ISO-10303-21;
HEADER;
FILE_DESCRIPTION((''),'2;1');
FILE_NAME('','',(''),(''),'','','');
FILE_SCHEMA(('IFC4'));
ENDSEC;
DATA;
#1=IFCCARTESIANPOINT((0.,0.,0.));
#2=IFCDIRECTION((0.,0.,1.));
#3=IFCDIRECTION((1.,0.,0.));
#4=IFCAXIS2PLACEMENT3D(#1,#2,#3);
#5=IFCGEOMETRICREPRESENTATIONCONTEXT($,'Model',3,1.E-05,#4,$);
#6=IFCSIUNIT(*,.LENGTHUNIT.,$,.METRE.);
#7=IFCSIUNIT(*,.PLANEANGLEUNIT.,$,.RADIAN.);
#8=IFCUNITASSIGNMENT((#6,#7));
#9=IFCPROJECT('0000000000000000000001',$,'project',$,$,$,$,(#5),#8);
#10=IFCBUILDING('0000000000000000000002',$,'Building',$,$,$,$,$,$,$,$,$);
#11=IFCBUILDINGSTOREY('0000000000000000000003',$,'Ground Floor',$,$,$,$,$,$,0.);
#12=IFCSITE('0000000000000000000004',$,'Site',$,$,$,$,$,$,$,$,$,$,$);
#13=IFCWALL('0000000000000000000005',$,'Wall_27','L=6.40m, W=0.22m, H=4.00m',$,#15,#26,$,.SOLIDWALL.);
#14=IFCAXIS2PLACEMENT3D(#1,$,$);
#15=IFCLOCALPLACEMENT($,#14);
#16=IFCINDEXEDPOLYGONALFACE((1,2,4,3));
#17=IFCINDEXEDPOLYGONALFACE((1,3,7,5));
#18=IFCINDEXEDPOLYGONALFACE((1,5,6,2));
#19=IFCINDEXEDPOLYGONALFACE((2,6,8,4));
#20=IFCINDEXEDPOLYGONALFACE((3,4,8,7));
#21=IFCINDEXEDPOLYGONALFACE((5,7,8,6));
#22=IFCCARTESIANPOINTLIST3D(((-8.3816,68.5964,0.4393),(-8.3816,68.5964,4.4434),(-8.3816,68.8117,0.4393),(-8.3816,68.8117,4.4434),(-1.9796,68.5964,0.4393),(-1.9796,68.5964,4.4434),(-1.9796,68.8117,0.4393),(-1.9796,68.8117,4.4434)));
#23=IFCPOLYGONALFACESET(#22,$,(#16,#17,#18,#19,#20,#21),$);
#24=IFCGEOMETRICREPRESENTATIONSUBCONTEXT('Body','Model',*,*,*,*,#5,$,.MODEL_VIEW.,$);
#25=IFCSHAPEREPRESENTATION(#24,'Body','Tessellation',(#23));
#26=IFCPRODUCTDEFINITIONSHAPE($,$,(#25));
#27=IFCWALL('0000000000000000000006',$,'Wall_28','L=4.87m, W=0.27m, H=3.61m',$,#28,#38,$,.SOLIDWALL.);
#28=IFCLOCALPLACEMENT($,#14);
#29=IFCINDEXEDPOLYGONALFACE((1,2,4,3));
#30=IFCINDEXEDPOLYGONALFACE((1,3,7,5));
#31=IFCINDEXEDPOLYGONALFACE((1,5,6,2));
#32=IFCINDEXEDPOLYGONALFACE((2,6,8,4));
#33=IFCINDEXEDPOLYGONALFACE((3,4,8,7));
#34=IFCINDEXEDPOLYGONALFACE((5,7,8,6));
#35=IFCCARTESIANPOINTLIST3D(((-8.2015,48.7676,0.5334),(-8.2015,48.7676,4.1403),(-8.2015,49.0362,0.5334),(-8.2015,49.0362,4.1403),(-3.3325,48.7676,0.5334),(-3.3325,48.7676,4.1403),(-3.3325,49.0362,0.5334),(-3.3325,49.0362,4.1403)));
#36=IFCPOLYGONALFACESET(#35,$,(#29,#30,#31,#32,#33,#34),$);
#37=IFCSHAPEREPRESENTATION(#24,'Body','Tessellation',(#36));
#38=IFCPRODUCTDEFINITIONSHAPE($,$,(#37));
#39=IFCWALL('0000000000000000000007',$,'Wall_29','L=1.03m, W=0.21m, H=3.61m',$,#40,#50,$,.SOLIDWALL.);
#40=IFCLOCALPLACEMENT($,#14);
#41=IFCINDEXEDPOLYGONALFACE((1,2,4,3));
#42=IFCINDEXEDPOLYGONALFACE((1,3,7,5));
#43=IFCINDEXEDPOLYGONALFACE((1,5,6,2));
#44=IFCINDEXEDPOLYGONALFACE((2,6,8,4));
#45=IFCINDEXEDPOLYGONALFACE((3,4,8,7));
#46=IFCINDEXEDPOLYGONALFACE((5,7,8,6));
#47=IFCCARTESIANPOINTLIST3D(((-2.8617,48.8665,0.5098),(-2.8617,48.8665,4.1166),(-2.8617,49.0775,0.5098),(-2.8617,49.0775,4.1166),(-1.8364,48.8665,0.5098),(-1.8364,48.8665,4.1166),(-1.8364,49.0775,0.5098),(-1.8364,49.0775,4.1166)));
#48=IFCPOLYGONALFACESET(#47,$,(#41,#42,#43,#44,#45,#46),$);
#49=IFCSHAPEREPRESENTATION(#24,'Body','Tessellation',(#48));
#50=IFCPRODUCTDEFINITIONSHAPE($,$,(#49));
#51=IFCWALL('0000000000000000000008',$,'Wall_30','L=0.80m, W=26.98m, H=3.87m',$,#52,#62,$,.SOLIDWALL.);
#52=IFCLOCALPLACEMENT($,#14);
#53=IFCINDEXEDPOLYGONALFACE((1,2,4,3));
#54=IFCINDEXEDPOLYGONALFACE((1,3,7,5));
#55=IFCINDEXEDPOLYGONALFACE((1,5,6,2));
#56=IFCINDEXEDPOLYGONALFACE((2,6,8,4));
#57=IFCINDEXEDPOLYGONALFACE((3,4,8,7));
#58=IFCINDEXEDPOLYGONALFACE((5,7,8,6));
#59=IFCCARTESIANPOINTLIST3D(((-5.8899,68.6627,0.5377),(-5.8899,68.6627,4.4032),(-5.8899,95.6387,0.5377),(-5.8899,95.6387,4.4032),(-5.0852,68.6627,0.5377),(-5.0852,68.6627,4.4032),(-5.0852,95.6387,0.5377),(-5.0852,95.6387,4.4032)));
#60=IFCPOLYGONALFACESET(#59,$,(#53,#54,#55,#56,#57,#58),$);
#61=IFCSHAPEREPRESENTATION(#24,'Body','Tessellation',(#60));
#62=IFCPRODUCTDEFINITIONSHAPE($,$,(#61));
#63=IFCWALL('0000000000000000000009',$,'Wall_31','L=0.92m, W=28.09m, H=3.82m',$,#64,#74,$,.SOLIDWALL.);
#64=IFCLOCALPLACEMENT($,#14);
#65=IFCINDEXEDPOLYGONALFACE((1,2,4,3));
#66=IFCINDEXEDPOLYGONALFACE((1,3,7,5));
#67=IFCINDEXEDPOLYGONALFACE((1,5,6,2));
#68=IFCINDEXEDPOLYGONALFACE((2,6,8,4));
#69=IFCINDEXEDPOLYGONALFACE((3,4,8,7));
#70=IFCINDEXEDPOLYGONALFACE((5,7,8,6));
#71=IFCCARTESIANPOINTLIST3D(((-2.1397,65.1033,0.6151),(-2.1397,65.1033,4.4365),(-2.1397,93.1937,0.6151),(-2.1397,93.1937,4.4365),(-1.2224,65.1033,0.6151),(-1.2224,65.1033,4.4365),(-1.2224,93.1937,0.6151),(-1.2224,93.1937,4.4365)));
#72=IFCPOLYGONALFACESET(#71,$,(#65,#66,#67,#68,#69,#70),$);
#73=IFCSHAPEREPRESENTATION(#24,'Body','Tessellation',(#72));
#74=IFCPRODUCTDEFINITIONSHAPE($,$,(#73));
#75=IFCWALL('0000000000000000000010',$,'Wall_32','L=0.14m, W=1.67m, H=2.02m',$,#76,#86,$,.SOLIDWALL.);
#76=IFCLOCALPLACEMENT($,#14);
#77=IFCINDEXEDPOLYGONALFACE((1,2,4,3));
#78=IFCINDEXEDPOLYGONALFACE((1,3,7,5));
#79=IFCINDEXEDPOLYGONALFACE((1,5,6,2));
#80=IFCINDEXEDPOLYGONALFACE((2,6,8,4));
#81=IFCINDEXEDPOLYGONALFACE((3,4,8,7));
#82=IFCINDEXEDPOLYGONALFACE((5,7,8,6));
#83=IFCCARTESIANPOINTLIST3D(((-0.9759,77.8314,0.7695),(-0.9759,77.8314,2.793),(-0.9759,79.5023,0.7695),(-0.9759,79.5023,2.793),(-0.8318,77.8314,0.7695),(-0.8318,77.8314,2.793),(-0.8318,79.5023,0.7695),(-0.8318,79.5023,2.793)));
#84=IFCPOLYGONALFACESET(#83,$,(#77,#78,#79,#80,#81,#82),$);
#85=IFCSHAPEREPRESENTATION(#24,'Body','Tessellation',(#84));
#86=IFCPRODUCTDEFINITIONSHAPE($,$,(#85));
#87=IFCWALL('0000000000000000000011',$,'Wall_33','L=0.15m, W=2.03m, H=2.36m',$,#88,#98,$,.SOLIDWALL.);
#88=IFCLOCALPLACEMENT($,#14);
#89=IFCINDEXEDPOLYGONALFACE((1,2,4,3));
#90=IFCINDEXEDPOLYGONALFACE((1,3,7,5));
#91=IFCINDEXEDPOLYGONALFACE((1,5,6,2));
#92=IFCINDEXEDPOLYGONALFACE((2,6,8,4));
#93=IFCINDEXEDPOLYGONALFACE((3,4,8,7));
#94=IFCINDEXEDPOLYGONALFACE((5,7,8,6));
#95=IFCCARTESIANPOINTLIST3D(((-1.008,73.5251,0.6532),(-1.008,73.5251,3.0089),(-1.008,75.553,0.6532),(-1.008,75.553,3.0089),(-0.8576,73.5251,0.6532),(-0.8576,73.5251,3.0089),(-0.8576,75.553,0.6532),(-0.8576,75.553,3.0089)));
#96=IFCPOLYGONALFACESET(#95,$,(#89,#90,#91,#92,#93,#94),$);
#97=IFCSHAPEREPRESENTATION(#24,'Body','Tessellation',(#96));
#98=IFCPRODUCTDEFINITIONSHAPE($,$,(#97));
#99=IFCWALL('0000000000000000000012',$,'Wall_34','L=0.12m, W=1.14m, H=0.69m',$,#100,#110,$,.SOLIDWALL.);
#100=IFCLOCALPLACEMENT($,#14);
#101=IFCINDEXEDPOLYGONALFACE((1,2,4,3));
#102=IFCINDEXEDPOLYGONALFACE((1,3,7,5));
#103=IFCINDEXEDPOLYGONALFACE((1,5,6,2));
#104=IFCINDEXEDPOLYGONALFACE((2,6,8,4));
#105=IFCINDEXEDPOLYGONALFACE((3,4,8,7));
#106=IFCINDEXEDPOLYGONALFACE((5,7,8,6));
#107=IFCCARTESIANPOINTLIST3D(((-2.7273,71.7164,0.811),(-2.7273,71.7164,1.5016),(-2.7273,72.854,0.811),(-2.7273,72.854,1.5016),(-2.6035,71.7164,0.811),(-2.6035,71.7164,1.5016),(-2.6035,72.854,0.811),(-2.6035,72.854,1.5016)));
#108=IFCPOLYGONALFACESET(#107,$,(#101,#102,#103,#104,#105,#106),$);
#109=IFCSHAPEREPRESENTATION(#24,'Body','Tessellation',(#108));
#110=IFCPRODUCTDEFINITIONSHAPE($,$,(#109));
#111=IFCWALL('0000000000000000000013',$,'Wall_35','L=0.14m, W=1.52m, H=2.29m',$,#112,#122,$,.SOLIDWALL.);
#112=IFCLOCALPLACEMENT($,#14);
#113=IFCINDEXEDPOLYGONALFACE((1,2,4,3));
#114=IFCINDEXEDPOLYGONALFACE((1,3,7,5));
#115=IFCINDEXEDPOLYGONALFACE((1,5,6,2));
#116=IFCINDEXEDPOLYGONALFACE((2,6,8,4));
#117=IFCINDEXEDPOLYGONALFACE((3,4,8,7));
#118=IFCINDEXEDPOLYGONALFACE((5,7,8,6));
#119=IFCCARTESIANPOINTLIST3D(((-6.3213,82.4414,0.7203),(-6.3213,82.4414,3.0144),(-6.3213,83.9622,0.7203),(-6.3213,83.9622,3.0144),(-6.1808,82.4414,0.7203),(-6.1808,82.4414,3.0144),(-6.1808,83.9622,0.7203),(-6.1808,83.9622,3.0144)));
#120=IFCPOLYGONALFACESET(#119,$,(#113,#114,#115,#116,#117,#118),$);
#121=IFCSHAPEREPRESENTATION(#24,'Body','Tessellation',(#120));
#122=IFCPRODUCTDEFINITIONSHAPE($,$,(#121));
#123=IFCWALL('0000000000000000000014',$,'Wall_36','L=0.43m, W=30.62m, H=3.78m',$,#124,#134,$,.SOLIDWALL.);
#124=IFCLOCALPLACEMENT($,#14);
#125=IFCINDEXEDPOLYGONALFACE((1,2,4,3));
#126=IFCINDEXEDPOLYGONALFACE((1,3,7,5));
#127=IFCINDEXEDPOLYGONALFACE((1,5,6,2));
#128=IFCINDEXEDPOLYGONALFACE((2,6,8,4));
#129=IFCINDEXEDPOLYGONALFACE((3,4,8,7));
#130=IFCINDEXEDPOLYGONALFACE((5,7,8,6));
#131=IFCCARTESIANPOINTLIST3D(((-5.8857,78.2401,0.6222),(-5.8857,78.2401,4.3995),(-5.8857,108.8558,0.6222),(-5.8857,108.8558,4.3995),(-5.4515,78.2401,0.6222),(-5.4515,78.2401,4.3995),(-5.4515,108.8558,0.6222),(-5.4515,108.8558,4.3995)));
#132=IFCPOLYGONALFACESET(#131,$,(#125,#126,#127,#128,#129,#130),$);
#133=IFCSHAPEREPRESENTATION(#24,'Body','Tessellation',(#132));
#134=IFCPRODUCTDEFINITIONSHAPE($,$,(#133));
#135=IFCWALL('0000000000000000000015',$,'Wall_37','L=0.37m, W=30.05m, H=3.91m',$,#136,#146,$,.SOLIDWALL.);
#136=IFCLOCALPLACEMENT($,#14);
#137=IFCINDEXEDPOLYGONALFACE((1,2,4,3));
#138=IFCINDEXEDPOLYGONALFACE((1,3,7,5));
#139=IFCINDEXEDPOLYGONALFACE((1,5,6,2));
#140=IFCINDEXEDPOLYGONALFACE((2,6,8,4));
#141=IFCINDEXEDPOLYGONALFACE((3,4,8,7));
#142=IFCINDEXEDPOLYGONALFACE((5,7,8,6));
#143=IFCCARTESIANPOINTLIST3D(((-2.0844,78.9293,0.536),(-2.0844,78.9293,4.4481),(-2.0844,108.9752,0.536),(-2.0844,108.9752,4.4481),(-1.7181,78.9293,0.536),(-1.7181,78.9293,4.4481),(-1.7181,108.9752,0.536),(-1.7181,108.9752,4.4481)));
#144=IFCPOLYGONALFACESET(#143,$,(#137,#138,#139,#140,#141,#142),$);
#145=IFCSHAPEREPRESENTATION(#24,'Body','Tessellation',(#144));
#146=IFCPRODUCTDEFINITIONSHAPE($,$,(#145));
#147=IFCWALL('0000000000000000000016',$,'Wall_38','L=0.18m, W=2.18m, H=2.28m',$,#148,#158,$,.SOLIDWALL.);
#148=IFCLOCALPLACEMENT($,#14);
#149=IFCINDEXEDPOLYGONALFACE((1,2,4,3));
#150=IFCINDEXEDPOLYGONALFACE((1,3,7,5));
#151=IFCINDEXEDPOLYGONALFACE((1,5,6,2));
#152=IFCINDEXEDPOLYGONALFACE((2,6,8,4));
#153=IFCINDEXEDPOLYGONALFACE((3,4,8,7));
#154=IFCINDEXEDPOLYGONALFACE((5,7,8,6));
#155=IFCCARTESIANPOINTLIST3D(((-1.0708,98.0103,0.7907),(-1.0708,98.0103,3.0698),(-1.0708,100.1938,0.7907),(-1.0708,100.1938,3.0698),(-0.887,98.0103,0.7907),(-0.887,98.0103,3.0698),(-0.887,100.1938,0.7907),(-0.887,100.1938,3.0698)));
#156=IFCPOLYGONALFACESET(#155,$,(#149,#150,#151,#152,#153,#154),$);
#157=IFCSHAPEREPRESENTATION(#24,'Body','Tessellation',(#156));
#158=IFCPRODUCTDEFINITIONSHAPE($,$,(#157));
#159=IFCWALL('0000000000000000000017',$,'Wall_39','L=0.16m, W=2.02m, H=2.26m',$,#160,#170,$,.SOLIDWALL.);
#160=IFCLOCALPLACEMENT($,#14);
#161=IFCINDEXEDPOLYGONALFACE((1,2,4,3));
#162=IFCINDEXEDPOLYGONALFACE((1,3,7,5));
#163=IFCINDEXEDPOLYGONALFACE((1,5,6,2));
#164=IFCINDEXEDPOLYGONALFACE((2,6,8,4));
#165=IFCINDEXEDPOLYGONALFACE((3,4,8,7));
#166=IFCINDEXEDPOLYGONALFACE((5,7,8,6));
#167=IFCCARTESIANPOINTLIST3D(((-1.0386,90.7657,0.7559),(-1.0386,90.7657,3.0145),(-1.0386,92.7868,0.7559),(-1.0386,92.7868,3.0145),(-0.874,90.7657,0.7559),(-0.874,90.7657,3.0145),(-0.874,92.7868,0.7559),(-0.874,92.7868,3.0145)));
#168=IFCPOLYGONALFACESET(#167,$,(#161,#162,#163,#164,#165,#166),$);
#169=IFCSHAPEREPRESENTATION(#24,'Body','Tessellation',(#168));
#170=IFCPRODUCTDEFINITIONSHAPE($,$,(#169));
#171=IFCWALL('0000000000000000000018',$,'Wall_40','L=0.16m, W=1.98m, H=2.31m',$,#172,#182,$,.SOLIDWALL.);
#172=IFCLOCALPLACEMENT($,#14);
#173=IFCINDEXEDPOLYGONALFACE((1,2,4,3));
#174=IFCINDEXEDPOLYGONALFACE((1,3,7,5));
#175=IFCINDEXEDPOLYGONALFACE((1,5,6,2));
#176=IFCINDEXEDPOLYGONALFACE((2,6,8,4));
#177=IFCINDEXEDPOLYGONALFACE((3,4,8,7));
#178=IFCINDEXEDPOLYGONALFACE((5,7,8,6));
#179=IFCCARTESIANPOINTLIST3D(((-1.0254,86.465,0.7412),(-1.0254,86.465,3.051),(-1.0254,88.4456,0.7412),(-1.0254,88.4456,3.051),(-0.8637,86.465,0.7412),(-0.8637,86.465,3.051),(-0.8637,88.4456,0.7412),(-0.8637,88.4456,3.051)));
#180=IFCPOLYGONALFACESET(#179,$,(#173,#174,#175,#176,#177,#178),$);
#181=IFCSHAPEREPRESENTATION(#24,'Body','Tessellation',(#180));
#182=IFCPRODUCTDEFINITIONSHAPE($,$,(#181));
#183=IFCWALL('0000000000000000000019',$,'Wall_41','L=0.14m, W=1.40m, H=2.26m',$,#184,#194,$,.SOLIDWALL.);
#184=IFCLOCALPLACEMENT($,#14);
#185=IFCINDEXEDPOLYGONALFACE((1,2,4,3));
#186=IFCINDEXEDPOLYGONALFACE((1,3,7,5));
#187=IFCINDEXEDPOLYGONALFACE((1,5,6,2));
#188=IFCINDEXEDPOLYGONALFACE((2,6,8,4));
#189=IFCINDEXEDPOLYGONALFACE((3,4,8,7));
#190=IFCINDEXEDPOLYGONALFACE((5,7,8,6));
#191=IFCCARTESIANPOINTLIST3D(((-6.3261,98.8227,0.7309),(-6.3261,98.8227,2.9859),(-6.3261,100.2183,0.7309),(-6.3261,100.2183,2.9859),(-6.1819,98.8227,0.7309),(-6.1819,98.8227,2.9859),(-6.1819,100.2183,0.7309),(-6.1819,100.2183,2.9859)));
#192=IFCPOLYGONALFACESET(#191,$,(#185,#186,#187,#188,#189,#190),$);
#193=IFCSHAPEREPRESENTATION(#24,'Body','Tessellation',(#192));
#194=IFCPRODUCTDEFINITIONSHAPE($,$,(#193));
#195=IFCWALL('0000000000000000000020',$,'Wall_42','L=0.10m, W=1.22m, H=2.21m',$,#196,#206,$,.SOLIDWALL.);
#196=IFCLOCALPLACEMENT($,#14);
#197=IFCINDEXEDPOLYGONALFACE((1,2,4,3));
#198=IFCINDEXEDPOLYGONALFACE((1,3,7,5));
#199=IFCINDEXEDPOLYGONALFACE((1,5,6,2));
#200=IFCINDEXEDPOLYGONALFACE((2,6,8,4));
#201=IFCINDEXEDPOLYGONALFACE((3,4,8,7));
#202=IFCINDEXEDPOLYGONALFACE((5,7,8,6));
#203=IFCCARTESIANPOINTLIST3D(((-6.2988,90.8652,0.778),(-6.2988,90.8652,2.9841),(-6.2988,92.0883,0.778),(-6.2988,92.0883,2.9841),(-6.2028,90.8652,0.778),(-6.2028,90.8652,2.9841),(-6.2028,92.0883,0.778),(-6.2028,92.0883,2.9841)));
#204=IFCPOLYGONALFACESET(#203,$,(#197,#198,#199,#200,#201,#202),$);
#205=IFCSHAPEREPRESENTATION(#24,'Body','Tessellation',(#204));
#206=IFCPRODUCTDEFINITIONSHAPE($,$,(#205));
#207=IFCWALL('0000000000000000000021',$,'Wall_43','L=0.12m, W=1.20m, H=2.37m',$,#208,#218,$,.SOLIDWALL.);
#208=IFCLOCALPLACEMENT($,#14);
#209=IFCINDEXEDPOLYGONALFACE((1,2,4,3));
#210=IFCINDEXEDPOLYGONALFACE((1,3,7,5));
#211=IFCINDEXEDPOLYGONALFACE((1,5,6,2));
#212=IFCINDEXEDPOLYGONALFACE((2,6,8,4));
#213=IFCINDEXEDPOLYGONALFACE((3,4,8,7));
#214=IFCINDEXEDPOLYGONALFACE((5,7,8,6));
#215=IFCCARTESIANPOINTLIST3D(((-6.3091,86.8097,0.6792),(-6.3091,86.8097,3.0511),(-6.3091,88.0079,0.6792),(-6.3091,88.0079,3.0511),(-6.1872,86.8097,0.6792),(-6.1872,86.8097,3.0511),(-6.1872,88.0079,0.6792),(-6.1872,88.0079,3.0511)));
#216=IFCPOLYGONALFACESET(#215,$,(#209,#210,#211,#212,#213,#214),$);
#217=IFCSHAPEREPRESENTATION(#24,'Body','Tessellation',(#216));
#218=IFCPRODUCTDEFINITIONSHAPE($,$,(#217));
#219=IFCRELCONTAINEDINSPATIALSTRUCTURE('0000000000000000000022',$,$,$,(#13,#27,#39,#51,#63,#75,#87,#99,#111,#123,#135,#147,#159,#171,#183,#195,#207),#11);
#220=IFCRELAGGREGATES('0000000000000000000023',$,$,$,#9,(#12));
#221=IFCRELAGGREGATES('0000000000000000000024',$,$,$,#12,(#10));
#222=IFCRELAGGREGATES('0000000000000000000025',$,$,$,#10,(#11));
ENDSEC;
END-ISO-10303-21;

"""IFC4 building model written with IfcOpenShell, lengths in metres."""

from ifc_helpers import new_model, si_unit, frame, origin_with_axes, origin_2d, context, subcontext, project, spatial, rectangle, extrude, element, save


model = new_model("IFC4")

# Units and contexts
model_context = context("Model", 3, precision=1e-05, world=origin_with_axes())
body_context = subcontext(model_context, "Body", "Model", "MODEL_VIEW")
ifc_project = project(units=[si_unit("LENGTHUNIT", "METRE"), si_unit("PLANEANGLEUNIT", "RADIAN")], contexts=[model_context])

# Site, building, storey
site = spatial("IfcSite", under=ifc_project, Name="Site")
building = spatial("IfcBuilding", under=site, Name="Building")
storey = spatial("IfcBuildingStorey", under=building, Name="Ground Floor", Elevation=0.0)

# Walls
element("IfcWall", 1, inside=storey, Name="Wall_27", Description="L=6.40m, W=0.22m, H=4.00m", PredefinedType="SOLIDWALL", context=body_context, shape_type="SweptSolid", body=[
    extrude(rectangle(XDim=6.4019, YDim=0.2153, at=origin_2d()), frame((-5.1806, 68.704, 0.4393), z_axis=(0.0, 0.0, 1.0), x_axis=(1.0, 0.0, 0.0)), (0.0, 0.0, 1.0), 4.0042),
])
element("IfcWall", 2, inside=storey, Name="Wall_28", Description="L=4.87m, W=0.27m, H=3.61m", PredefinedType="SOLIDWALL", context=body_context, shape_type="SweptSolid", body=[
    extrude(rectangle(XDim=4.869, YDim=0.2687, at=origin_2d()), frame((-5.767, 48.9019, 0.5334), z_axis=(0.0, 0.0, 1.0), x_axis=(1.0, 0.0, 0.0)), (0.0, 0.0, 1.0), 3.6069),
])
element("IfcWall", 3, inside=storey, Name="Wall_29", Description="L=1.03m, W=0.21m, H=3.61m", PredefinedType="SOLIDWALL", context=body_context, shape_type="SweptSolid", body=[
    extrude(rectangle(XDim=1.0253, YDim=0.211, at=origin_2d()), frame((-2.349, 48.972, 0.5098), z_axis=(0.0, 0.0, 1.0), x_axis=(1.0, 0.0, 0.0)), (0.0, 0.0, 1.0), 3.6068),
])
element("IfcWall", 4, inside=storey, Name="Wall_30", Description="L=0.80m, W=26.98m, H=3.87m", PredefinedType="SOLIDWALL", context=body_context, shape_type="SweptSolid", body=[
    extrude(rectangle(XDim=0.8047, YDim=26.976, at=origin_2d()), frame((-5.4875, 82.1507, 0.5377), z_axis=(0.0, 0.0, 1.0), x_axis=(1.0, 0.0, 0.0)), (0.0, 0.0, 1.0), 3.8655),
])
element("IfcWall", 5, inside=storey, Name="Wall_31", Description="L=0.92m, W=28.09m, H=3.82m", PredefinedType="SOLIDWALL", context=body_context, shape_type="SweptSolid", body=[
    extrude(rectangle(XDim=0.9173, YDim=28.0904, at=origin_2d()), frame((-1.681, 79.1485, 0.6151), z_axis=(0.0, 0.0, 1.0), x_axis=(1.0, 0.0, 0.0)), (0.0, 0.0, 1.0), 3.8214),
])
element("IfcWall", 6, inside=storey, Name="Wall_32", Description="L=0.14m, W=1.67m, H=2.02m", PredefinedType="SOLIDWALL", context=body_context, shape_type="SweptSolid", body=[
    extrude(rectangle(XDim=0.1441, YDim=1.6709, at=origin_2d()), frame((-0.9039, 78.6669, 0.7695), z_axis=(0.0, 0.0, 1.0), x_axis=(1.0, 0.0, 0.0)), (0.0, 0.0, 1.0), 2.0235),
])
element("IfcWall", 7, inside=storey, Name="Wall_33", Description="L=0.15m, W=2.03m, H=2.36m", PredefinedType="SOLIDWALL", context=body_context, shape_type="SweptSolid", body=[
    extrude(rectangle(XDim=0.1504, YDim=2.0278, at=origin_2d()), frame((-0.9328, 74.5391, 0.6532), z_axis=(0.0, 0.0, 1.0), x_axis=(1.0, 0.0, 0.0)), (0.0, 0.0, 1.0), 2.3556),
])
element("IfcWall", 8, inside=storey, Name="Wall_34", Description="L=0.12m, W=1.14m, H=0.69m", PredefinedType="SOLIDWALL", context=body_context, shape_type="SweptSolid", body=[
    extrude(rectangle(XDim=0.1238, YDim=1.1376, at=origin_2d()), frame((-2.6654, 72.2852, 0.811), z_axis=(0.0, 0.0, 1.0), x_axis=(1.0, 0.0, 0.0)), (0.0, 0.0, 1.0), 0.6906),
])
element("IfcWall", 9, inside=storey, Name="Wall_35", Description="L=0.14m, W=1.52m, H=2.29m", PredefinedType="SOLIDWALL", context=body_context, shape_type="SweptSolid", body=[
    extrude(rectangle(XDim=0.1405, YDim=1.5208, at=origin_2d()), frame((-6.2511, 83.2018, 0.7203), z_axis=(0.0, 0.0, 1.0), x_axis=(1.0, 0.0, 0.0)), (0.0, 0.0, 1.0), 2.2941),
])
element("IfcWall", 10, inside=storey, Name="Wall_36", Description="L=0.43m, W=30.62m, H=3.78m", PredefinedType="SOLIDWALL", context=body_context, shape_type="SweptSolid", body=[
    extrude(rectangle(XDim=0.4342, YDim=30.6157, at=origin_2d()), frame((-5.6686, 93.548, 0.6222), z_axis=(0.0, 0.0, 1.0), x_axis=(1.0, 0.0, 0.0)), (0.0, 0.0, 1.0), 3.7773),
])
element("IfcWall", 11, inside=storey, Name="Wall_37", Description="L=0.37m, W=30.05m, H=3.91m", PredefinedType="SOLIDWALL", context=body_context, shape_type="SweptSolid", body=[
    extrude(rectangle(XDim=0.3662, YDim=30.0459, at=origin_2d()), frame((-1.9013, 93.9522, 0.536), z_axis=(0.0, 0.0, 1.0), x_axis=(1.0, 0.0, 0.0)), (0.0, 0.0, 1.0), 3.9121),
])
element("IfcWall", 12, inside=storey, Name="Wall_38", Description="L=0.18m, W=2.18m, H=2.28m", PredefinedType="SOLIDWALL", context=body_context, shape_type="SweptSolid", body=[
    extrude(rectangle(XDim=0.1838, YDim=2.1834, at=origin_2d()), frame((-0.9789, 99.102, 0.7907), z_axis=(0.0, 0.0, 1.0), x_axis=(1.0, 0.0, 0.0)), (0.0, 0.0, 1.0), 2.279),
])
element("IfcWall", 13, inside=storey, Name="Wall_39", Description="L=0.16m, W=2.02m, H=2.26m", PredefinedType="SOLIDWALL", context=body_context, shape_type="SweptSolid", body=[
    extrude(rectangle(XDim=0.1646, YDim=2.021, at=origin_2d()), frame((-0.9563, 91.7763, 0.7559), z_axis=(0.0, 0.0, 1.0), x_axis=(1.0, 0.0, 0.0)), (0.0, 0.0, 1.0), 2.2587),
])
element("IfcWall", 14, inside=storey, Name="Wall_40", Description="L=0.16m, W=1.98m, H=2.31m", PredefinedType="SOLIDWALL", context=body_context, shape_type="SweptSolid", body=[
    extrude(rectangle(XDim=0.1618, YDim=1.9806, at=origin_2d()), frame((-0.9446, 87.4553, 0.7412), z_axis=(0.0, 0.0, 1.0), x_axis=(1.0, 0.0, 0.0)), (0.0, 0.0, 1.0), 2.3097),
])
element("IfcWall", 15, inside=storey, Name="Wall_41", Description="L=0.14m, W=1.40m, H=2.26m", PredefinedType="SOLIDWALL", context=body_context, shape_type="SweptSolid", body=[
    extrude(rectangle(XDim=0.1442, YDim=1.3956, at=origin_2d()), frame((-6.254, 99.5205, 0.7309), z_axis=(0.0, 0.0, 1.0), x_axis=(1.0, 0.0, 0.0)), (0.0, 0.0, 1.0), 2.255),
])
element("IfcWall", 16, inside=storey, Name="Wall_42", Description="L=0.10m, W=1.22m, H=2.21m", PredefinedType="SOLIDWALL", context=body_context, shape_type="SweptSolid", body=[
    extrude(rectangle(XDim=0.096, YDim=1.2231, at=origin_2d()), frame((-6.2508, 91.4767, 0.778), z_axis=(0.0, 0.0, 1.0), x_axis=(1.0, 0.0, 0.0)), (0.0, 0.0, 1.0), 2.2061),
])
element("IfcWall", 17, inside=storey, Name="Wall_43", Description="L=0.12m, W=1.20m, H=2.37m", PredefinedType="SOLIDWALL", context=body_context, shape_type="SweptSolid", body=[
    extrude(rectangle(XDim=0.1219, YDim=1.1983, at=origin_2d()), frame((-6.2481, 87.4088, 0.6792), z_axis=(0.0, 0.0, 1.0), x_axis=(1.0, 0.0, 0.0)), (0.0, 0.0, 1.0), 2.3719),
])

save(model, "model.ifc")
